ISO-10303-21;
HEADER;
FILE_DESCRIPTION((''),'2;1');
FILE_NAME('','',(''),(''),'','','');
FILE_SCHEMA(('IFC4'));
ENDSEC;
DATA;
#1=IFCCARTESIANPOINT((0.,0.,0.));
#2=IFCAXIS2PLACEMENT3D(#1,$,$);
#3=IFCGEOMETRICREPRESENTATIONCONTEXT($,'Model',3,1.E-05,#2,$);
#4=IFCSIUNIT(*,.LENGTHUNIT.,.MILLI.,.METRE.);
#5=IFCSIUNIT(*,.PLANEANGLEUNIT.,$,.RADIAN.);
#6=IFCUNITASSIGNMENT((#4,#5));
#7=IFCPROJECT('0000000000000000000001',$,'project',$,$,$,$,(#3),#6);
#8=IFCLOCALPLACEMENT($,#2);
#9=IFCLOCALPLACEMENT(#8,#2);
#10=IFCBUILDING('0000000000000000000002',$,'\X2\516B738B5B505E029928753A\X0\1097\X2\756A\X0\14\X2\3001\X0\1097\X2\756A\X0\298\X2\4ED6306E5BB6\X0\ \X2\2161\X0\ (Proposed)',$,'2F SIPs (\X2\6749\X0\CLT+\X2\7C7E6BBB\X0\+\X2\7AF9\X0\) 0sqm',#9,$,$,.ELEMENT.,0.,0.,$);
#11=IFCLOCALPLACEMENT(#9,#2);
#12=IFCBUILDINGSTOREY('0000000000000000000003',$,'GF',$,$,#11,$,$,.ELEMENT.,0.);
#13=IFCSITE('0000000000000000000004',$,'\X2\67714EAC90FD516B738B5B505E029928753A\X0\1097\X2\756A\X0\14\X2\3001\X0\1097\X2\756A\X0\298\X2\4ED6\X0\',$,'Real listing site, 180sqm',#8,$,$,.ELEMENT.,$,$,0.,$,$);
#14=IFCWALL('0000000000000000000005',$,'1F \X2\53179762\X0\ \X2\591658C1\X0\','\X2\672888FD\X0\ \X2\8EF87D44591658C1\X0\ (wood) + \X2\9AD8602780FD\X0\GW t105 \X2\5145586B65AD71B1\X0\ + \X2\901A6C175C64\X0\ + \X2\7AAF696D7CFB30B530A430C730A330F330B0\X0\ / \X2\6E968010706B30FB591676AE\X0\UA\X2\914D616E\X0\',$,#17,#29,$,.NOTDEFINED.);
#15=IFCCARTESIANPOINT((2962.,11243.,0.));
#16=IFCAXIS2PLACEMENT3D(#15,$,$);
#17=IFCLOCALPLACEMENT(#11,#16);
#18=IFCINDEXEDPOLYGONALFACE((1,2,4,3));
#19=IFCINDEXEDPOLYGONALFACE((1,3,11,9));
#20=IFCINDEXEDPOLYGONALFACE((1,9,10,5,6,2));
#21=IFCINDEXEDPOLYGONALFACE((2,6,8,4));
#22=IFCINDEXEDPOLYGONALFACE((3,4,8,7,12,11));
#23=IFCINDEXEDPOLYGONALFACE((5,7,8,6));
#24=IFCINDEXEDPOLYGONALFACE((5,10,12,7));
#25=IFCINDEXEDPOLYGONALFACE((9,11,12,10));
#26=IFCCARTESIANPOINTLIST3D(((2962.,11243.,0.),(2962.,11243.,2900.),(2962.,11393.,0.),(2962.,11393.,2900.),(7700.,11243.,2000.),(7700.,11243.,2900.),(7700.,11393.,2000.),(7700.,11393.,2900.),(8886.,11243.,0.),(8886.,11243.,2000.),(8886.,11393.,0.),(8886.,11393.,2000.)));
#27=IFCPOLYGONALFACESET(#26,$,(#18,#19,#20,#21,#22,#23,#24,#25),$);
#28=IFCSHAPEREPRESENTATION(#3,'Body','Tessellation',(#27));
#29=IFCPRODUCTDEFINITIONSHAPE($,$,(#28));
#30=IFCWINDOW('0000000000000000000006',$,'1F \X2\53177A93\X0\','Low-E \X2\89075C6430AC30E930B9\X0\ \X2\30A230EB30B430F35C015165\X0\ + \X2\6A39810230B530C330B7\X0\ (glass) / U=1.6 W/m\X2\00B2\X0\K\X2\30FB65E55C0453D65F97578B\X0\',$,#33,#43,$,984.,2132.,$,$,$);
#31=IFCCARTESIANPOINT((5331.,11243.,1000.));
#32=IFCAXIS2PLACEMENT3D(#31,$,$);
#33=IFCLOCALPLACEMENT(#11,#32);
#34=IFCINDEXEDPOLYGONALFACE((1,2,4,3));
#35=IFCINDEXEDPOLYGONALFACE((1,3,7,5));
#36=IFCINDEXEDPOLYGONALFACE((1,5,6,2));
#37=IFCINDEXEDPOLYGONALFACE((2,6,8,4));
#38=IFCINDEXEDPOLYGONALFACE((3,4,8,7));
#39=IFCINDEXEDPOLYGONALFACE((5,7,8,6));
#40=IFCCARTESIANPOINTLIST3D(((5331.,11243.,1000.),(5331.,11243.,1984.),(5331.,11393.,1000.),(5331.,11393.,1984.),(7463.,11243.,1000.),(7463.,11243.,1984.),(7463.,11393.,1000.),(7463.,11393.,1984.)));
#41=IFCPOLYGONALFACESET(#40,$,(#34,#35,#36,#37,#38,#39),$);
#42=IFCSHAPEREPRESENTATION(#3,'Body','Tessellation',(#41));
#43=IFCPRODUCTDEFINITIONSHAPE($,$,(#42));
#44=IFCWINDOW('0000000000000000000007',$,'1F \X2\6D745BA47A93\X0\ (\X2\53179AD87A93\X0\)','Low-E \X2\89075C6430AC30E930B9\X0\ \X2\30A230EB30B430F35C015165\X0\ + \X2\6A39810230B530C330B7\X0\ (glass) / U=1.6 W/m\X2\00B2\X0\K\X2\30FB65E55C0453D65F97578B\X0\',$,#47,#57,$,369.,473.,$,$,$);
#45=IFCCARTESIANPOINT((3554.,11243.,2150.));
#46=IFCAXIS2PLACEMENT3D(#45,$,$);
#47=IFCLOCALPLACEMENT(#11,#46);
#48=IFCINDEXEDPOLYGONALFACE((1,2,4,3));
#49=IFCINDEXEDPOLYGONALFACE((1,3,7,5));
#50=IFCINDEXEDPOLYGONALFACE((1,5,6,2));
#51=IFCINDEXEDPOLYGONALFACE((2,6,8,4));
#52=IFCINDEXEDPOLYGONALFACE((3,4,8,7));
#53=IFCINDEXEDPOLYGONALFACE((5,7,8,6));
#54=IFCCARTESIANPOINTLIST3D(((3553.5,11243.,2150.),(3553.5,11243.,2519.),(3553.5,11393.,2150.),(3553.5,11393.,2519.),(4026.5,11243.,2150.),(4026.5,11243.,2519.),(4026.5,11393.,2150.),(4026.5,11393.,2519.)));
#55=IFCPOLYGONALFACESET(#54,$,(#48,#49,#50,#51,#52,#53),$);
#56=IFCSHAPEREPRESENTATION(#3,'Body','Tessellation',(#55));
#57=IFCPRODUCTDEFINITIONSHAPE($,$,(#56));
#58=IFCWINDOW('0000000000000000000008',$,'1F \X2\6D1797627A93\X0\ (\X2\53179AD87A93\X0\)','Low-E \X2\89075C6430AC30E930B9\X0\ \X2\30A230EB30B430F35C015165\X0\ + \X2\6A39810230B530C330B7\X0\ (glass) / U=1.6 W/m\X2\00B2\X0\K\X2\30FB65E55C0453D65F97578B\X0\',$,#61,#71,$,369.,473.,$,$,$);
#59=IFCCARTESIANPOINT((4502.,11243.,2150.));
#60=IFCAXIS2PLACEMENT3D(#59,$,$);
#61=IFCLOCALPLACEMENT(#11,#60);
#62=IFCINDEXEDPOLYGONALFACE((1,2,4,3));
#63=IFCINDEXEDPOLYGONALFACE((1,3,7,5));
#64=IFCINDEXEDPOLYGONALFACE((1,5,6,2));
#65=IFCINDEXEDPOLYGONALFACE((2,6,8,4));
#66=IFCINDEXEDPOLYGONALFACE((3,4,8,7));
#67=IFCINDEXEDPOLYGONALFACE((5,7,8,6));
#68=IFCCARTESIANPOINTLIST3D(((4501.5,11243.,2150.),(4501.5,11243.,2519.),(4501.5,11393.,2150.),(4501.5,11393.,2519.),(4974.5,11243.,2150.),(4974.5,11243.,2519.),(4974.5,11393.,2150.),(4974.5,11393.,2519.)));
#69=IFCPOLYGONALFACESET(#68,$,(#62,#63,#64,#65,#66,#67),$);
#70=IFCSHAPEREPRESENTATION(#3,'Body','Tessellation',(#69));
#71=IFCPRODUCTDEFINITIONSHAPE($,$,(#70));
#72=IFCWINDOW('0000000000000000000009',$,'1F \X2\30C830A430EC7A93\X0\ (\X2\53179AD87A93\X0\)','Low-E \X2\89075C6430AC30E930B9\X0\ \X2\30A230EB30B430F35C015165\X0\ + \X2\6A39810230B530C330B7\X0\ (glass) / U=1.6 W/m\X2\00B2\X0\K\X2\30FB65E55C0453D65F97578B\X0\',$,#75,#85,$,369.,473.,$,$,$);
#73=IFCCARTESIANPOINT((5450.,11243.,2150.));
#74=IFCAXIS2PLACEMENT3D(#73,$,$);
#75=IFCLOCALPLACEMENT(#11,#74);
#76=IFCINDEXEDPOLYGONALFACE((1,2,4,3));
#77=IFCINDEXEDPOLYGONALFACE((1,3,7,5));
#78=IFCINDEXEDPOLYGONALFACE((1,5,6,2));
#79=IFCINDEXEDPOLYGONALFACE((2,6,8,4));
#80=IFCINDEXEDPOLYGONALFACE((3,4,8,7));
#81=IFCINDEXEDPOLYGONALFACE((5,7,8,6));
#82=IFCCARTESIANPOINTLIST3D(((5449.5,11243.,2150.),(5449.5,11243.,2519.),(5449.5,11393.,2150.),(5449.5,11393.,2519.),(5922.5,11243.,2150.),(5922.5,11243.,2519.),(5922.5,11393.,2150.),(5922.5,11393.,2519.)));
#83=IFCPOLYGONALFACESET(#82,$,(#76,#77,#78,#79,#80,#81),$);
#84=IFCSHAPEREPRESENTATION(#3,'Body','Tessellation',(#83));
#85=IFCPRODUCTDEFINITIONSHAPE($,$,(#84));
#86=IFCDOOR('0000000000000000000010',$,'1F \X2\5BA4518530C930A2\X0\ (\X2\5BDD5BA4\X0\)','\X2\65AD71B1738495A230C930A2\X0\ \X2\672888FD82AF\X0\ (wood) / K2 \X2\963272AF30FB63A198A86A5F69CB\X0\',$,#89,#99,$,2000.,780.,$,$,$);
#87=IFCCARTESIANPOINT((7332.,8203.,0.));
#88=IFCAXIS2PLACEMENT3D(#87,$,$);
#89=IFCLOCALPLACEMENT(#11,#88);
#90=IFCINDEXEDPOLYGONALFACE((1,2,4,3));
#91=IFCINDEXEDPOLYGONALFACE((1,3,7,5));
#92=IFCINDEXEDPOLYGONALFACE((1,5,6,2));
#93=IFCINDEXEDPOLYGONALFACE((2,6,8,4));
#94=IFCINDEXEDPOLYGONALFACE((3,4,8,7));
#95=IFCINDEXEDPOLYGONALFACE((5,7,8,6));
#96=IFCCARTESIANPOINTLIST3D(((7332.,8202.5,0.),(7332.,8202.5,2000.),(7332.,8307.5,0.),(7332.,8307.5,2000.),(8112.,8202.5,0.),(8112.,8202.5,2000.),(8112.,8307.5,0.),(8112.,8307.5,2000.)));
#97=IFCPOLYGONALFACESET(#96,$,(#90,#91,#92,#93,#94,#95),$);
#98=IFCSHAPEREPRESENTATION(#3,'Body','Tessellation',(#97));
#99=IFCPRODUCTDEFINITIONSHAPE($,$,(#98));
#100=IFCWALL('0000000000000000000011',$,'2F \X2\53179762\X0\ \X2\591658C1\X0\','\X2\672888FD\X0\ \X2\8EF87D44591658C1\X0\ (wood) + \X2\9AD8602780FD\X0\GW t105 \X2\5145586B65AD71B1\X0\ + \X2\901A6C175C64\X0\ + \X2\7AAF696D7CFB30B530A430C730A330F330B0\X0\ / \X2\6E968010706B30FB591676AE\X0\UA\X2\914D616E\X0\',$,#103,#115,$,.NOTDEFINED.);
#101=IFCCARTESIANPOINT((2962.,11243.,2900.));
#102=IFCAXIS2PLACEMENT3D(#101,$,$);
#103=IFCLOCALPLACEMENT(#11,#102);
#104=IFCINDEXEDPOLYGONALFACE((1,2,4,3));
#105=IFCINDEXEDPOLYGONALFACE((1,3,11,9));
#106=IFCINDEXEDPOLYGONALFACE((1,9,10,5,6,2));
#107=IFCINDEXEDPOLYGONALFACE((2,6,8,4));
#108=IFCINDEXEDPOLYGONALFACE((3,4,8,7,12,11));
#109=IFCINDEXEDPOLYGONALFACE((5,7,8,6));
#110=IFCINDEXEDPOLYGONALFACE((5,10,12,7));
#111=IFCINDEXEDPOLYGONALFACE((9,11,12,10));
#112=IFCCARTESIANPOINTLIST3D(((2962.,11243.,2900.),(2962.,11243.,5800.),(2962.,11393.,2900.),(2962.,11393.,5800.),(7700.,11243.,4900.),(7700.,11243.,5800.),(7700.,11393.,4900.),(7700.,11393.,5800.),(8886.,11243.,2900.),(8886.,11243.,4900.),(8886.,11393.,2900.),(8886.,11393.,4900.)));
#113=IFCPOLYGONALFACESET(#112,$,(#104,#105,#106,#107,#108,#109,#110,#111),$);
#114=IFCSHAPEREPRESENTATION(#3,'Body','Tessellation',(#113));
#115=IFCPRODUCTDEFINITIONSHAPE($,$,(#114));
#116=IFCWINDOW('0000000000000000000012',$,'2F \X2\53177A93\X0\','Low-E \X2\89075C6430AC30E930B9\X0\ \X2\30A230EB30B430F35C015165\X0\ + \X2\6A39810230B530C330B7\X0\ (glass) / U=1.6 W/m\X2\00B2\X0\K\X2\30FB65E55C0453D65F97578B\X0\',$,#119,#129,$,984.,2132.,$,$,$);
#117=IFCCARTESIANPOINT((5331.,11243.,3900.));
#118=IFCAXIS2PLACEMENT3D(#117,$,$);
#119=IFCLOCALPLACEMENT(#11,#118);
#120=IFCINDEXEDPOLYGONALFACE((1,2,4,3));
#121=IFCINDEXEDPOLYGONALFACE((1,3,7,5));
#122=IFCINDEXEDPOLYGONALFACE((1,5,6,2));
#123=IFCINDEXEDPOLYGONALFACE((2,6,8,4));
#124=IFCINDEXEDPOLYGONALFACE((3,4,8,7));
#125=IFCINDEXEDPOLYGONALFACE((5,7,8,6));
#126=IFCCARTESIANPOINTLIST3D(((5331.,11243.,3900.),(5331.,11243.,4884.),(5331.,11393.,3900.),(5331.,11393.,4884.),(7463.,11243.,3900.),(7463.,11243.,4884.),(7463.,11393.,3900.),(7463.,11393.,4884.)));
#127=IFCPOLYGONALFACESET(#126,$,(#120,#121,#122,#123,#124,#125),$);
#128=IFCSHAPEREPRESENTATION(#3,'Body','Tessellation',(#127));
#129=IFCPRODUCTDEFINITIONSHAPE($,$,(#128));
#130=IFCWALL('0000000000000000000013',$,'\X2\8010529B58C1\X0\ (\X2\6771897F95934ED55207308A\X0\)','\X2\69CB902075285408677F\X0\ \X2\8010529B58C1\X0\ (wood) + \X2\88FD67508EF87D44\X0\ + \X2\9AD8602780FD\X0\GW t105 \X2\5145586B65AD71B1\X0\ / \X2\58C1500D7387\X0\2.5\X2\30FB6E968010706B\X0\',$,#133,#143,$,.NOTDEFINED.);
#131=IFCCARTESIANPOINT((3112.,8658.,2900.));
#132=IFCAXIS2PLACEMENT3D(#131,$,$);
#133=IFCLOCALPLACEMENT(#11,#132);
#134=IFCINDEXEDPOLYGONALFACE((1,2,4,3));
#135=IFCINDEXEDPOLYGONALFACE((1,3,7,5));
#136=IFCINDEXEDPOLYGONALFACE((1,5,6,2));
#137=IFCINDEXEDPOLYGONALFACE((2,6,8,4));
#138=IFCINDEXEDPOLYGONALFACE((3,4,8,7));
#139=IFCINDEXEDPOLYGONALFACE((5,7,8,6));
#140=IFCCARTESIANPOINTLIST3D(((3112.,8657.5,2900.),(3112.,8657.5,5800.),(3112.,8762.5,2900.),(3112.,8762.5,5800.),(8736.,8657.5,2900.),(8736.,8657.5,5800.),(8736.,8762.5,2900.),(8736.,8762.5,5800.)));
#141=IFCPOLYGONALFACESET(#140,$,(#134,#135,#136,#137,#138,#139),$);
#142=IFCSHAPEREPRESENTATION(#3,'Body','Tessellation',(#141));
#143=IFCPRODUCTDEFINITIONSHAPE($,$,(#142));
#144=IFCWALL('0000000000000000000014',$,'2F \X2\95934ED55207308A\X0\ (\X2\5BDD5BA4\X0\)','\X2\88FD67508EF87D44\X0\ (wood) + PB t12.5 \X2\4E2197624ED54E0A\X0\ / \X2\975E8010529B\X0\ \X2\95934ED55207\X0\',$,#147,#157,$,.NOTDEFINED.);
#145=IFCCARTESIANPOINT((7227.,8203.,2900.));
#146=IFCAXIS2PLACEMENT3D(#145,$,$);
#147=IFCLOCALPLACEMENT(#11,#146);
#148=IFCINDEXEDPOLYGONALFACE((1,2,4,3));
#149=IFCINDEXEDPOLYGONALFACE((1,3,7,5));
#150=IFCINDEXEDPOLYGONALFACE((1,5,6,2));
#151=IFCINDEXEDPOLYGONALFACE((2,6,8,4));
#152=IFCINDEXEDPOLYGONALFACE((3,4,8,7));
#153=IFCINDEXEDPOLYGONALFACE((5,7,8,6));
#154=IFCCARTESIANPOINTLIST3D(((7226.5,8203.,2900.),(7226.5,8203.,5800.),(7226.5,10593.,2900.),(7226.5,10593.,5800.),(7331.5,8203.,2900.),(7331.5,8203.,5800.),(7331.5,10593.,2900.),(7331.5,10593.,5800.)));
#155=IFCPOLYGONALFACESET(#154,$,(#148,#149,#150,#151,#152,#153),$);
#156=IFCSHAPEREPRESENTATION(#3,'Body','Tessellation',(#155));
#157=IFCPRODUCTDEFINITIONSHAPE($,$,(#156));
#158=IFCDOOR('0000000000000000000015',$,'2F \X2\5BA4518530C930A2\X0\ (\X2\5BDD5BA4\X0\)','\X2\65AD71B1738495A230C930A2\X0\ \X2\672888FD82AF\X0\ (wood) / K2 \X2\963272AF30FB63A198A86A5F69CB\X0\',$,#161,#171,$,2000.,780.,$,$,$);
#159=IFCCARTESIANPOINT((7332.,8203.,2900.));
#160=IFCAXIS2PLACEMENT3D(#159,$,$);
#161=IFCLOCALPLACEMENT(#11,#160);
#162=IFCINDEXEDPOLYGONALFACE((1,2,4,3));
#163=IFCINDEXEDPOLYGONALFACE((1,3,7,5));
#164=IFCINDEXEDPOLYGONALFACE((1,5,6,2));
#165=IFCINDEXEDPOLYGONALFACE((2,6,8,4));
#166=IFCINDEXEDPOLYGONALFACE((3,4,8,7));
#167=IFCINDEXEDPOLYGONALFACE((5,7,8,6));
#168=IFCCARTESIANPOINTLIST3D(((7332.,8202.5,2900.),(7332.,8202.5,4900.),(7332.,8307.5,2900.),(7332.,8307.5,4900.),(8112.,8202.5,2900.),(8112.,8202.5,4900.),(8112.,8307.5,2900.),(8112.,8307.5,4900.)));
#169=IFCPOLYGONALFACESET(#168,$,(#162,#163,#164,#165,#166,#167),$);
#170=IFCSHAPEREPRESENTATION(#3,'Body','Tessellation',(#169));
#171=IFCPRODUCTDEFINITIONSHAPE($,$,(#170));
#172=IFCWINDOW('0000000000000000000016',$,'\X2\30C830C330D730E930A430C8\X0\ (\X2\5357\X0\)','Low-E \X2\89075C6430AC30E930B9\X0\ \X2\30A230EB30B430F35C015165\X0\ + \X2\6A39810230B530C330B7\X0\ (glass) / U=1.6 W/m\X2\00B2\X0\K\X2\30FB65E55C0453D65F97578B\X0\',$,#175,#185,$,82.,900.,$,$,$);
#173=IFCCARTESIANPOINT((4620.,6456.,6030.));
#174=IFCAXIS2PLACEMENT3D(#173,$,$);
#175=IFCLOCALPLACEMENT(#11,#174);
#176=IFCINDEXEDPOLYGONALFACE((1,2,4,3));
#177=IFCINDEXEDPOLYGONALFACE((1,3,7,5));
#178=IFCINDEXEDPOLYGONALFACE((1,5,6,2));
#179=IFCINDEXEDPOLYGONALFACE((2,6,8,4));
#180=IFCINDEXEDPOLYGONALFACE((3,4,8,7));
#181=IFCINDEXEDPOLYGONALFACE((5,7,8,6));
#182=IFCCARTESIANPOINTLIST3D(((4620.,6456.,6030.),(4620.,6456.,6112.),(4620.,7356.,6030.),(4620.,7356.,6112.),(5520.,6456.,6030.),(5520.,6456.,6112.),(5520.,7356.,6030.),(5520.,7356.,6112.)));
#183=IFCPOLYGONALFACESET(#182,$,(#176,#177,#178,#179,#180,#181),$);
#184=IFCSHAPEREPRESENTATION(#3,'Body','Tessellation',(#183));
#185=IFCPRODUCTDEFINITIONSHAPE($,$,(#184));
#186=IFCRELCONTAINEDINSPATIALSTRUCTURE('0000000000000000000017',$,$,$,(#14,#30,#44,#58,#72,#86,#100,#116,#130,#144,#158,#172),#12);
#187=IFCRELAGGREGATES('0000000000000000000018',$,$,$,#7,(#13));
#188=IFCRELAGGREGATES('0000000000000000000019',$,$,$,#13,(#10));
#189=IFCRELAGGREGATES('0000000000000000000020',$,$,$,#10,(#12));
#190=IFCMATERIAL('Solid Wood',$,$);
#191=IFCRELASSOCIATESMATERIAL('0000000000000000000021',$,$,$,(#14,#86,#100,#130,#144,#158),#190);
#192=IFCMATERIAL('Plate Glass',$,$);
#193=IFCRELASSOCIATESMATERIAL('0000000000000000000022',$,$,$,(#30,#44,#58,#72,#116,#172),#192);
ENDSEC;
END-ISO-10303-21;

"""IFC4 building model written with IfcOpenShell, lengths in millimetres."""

from ifc_helpers import new_model, si_unit, frame, frame_2d, origin, place, context, project, spatial, rectangle, extrude, material, element, fill, save


model = new_model("IFC4")

# Units and contexts
model_context = context("Model", 3, precision=1e-05, world=origin())
ifc_project = project(units=[si_unit("LENGTHUNIT", "METRE", prefix="MILLI"), si_unit("PLANEANGLEUNIT", "RADIAN")], contexts=[model_context])

# Site, building, storey
site_placement = place(None, origin())
site = spatial("IfcSite", under=ifc_project, at=site_placement, Name="東京都八王子市館町1097番14、1097番298他", ObjectType="Real listing site, 180sqm", CompositionType="ELEMENT", RefElevation=0.0)
building_placement = place(site_placement, origin())
building = spatial("IfcBuilding", under=site, at=building_placement, Name="八王子市館町1097番14、1097番298他の家 Ⅱ (Proposed)", ObjectType="2F SIPs (杉CLT+籾殻+竹) 0sqm", CompositionType="ELEMENT", ElevationOfRefHeight=0.0, ElevationOfTerrain=0.0)
storey_placement = place(building_placement, origin())
storey = spatial("IfcBuildingStorey", under=building, at=storey_placement, Name="GF", CompositionType="ELEMENT", Elevation=0.0)

# Wall, openings, windows
ifc_material_1 = material(Name="Solid Wood")
wall_1_placement = place(storey_placement, frame((2962.0, 11243.0, 0.0)))
wall_1 = element("IfcWall", 1, at=wall_1_placement, inside=storey, material=ifc_material_1, Name="1F 北面 外壁", Description="木製 軸組外壁 (wood) + 高性能GW t105 充填断熱 + 通気層 + 窯業系サイディング / 準耐火・外皮UA配慮", PredefinedType="NOTDEFINED", context=model_context, shape_type="SweptSolid", body=[
    extrude(rectangle(XDim=5924.0, YDim=150.0, at=frame_2d((2962.0, 75.0))), frame((2962.0, 11243.0, 0.0)), (0.0, 0.0, 1.0), 2900.0),
])
opening_1_placement = place(storey_placement, frame((5331.0, 11243.0, 1000.0)))
opening_1 = element("IfcOpeningElement", 2, at=opening_1_placement, cuts=wall_1, PredefinedType="NOTDEFINED", context=model_context, shape_type="SweptSolid", body=[
    extrude(rectangle(XDim=2132.0, YDim=150.0, at=frame_2d((1066.0, 75.0))), frame((5331.0, 11243.0, 1000.0)), (0.0, 0.0, 1.0), 984.0),
])
opening_2_placement = place(storey_placement, frame((3554.0, 11243.0, 2150.0)))
opening_2 = element("IfcOpeningElement", 3, at=opening_2_placement, cuts=wall_1, PredefinedType="NOTDEFINED", context=model_context, shape_type="SweptSolid", body=[
    extrude(rectangle(XDim=473.0, YDim=150.0, at=frame_2d((236.0, 75.0))), frame((3554.0, 11243.0, 2150.0)), (0.0, 0.0, 1.0), 369.0),
])
opening_3_placement = place(storey_placement, frame((4502.0, 11243.0, 2150.0)))
opening_3 = element("IfcOpeningElement", 4, at=opening_3_placement, cuts=wall_1, PredefinedType="NOTDEFINED", context=model_context, shape_type="SweptSolid", body=[
    extrude(rectangle(XDim=473.0, YDim=150.0, at=frame_2d((236.0, 75.0))), frame((4502.0, 11243.0, 2150.0)), (0.0, 0.0, 1.0), 369.0),
])
opening_4_placement = place(storey_placement, frame((5450.0, 11243.0, 2150.0)))
opening_4 = element("IfcOpeningElement", 5, at=opening_4_placement, cuts=wall_1, PredefinedType="NOTDEFINED", context=model_context, shape_type="SweptSolid", body=[
    extrude(rectangle(XDim=473.0, YDim=150.0, at=frame_2d((236.0, 75.0))), frame((5450.0, 11243.0, 2150.0)), (0.0, 0.0, 1.0), 369.0),
])
ifc_material_2 = material(Name="Plate Glass")
window_1_placement = place(storey_placement, frame((5331.0, 11243.0, 1000.0)))
window_1 = element("IfcWindow", 6, at=window_1_placement, inside=storey, material=ifc_material_2, Name="1F 北窓", Description="Low-E 複層ガラス アルゴン封入 + 樹脂サッシ (glass) / U=1.6 W/m²K・日射取得型", OverallHeight=984.0, OverallWidth=2132.0, context=model_context, shape_type="SweptSolid", body=[
    extrude(rectangle(XDim=2132.0, YDim=150.0, at=frame_2d((1066.0, 75.0))), frame((5331.0, 11243.0, 1000.0)), (0.0, 0.0, 1.0), 984.0),
])
fill(opening_1, window_1)
window_2_placement = place(storey_placement, frame((3554.0, 11243.0, 2150.0)))
window_2 = element("IfcWindow", 7, at=window_2_placement, inside=storey, material=ifc_material_2, Name="1F 浴室窓 (北高窓)", Description="Low-E 複層ガラス アルゴン封入 + 樹脂サッシ (glass) / U=1.6 W/m²K・日射取得型", OverallHeight=369.0, OverallWidth=473.0, context=model_context, shape_type="SweptSolid", body=[
    extrude(rectangle(XDim=473.0, YDim=150.0, at=frame_2d((236.0, 75.0))), frame((3554.0, 11243.0, 2150.0)), (0.0, 0.0, 1.0), 369.0),
])
fill(opening_2, window_2)
window_3_placement = place(storey_placement, frame((4502.0, 11243.0, 2150.0)))
window_3 = element("IfcWindow", 8, at=window_3_placement, inside=storey, material=ifc_material_2, Name="1F 洗面窓 (北高窓)", Description="Low-E 複層ガラス アルゴン封入 + 樹脂サッシ (glass) / U=1.6 W/m²K・日射取得型", OverallHeight=369.0, OverallWidth=473.0, context=model_context, shape_type="SweptSolid", body=[
    extrude(rectangle(XDim=473.0, YDim=150.0, at=frame_2d((236.0, 75.0))), frame((4502.0, 11243.0, 2150.0)), (0.0, 0.0, 1.0), 369.0),
])
fill(opening_3, window_3)
window_4_placement = place(storey_placement, frame((5450.0, 11243.0, 2150.0)))
window_4 = element("IfcWindow", 9, at=window_4_placement, inside=storey, material=ifc_material_2, Name="1F トイレ窓 (北高窓)", Description="Low-E 複層ガラス アルゴン封入 + 樹脂サッシ (glass) / U=1.6 W/m²K・日射取得型", OverallHeight=369.0, OverallWidth=473.0, context=model_context, shape_type="SweptSolid", body=[
    extrude(rectangle(XDim=473.0, YDim=150.0, at=frame_2d((236.0, 75.0))), frame((5450.0, 11243.0, 2150.0)), (0.0, 0.0, 1.0), 369.0),
])
fill(opening_4, window_4)

# Door
door_1_placement = place(storey_placement, frame((7332.0, 8203.0, 0.0)))
element("IfcDoor", 10, at=door_1_placement, inside=storey, material=ifc_material_1, Name="1F 室内ドア (寝室)", Description="断熱玄関ドア 木製芯 (wood) / K2 防犯・採風機構", OverallHeight=2000.0, OverallWidth=780.0, context=model_context, shape_type="SweptSolid", body=[
    extrude(rectangle(XDim=780.0, YDim=105.0, at=frame_2d((390.0, 52.0))), frame((7332.0, 8203.0, 0.0)), (0.0, 0.0, 1.0), 2000.0),
])

# Wall, opening, window
wall_2_placement = place(storey_placement, frame((2962.0, 11243.0, 2900.0)))
wall_2 = element("IfcWall", 11, at=wall_2_placement, inside=storey, material=ifc_material_1, Name="2F 北面 外壁", Description="木製 軸組外壁 (wood) + 高性能GW t105 充填断熱 + 通気層 + 窯業系サイディング / 準耐火・外皮UA配慮", PredefinedType="NOTDEFINED", context=model_context, shape_type="SweptSolid", body=[
    extrude(rectangle(XDim=5924.0, YDim=150.0, at=frame_2d((2962.0, 75.0))), frame((2962.0, 11243.0, 2900.0)), (0.0, 0.0, 1.0), 2900.0),
])
opening_5_placement = place(storey_placement, frame((5331.0, 11243.0, 3900.0)))
opening_5 = element("IfcOpeningElement", 12, at=opening_5_placement, cuts=wall_2, PredefinedType="NOTDEFINED", context=model_context, shape_type="SweptSolid", body=[
    extrude(rectangle(XDim=2132.0, YDim=150.0, at=frame_2d((1066.0, 75.0))), frame((5331.0, 11243.0, 3900.0)), (0.0, 0.0, 1.0), 984.0),
])
window_5_placement = place(storey_placement, frame((5331.0, 11243.0, 3900.0)))
window_5 = element("IfcWindow", 13, at=window_5_placement, inside=storey, material=ifc_material_2, Name="2F 北窓", Description="Low-E 複層ガラス アルゴン封入 + 樹脂サッシ (glass) / U=1.6 W/m²K・日射取得型", OverallHeight=984.0, OverallWidth=2132.0, context=model_context, shape_type="SweptSolid", body=[
    extrude(rectangle(XDim=2132.0, YDim=150.0, at=frame_2d((1066.0, 75.0))), frame((5331.0, 11243.0, 3900.0)), (0.0, 0.0, 1.0), 984.0),
])
fill(opening_5, window_5)

# Walls
wall_3_placement = place(storey_placement, frame((3112.0, 8658.0, 2900.0)))
element("IfcWall", 14, at=wall_3_placement, inside=storey, material=ifc_material_1, Name="耐力壁 (東西間仕切り)", Description="構造用合板 耐力壁 (wood) + 製材軸組 + 高性能GW t105 充填断熱 / 壁倍率2.5・準耐火", PredefinedType="NOTDEFINED", context=model_context, shape_type="SweptSolid", body=[
    extrude(rectangle(XDim=5624.0, YDim=105.0, at=frame_2d((2812.0, 52.0))), frame((3112.0, 8658.0, 2900.0)), (0.0, 0.0, 1.0), 2900.0),
])
wall_4_placement = place(storey_placement, frame((7227.0, 8203.0, 2900.0)))
element("IfcWall", 15, at=wall_4_placement, inside=storey, material=ifc_material_1, Name="2F 間仕切り (寝室)", Description="製材軸組 (wood) + PB t12.5 両面仕上 / 非耐力 間仕切", PredefinedType="NOTDEFINED", context=model_context, shape_type="SweptSolid", body=[
    extrude(rectangle(XDim=105.0, YDim=2390.0, at=frame_2d((52.0, 1195.0))), frame((7227.0, 8203.0, 2900.0)), (0.0, 0.0, 1.0), 2900.0),
])

# Door
door_2_placement = place(storey_placement, frame((7332.0, 8203.0, 2900.0)))
element("IfcDoor", 16, at=door_2_placement, inside=storey, material=ifc_material_1, Name="2F 室内ドア (寝室)", Description="断熱玄関ドア 木製芯 (wood) / K2 防犯・採風機構", OverallHeight=2000.0, OverallWidth=780.0, context=model_context, shape_type="SweptSolid", body=[
    extrude(rectangle(XDim=780.0, YDim=105.0, at=frame_2d((390.0, 52.0))), frame((7332.0, 8203.0, 2900.0)), (0.0, 0.0, 1.0), 2000.0),
])

# Window
window_6_placement = place(storey_placement, frame((4620.0, 6456.0, 6030.0)))
element("IfcWindow", 17, at=window_6_placement, inside=storey, material=ifc_material_2, Name="トップライト (南)", Description="Low-E 複層ガラス アルゴン封入 + 樹脂サッシ (glass) / U=1.6 W/m²K・日射取得型", OverallHeight=82.0, OverallWidth=900.0, context=model_context, shape_type="SweptSolid", body=[
    extrude(rectangle(XDim=900.0, YDim=900.0, at=frame_2d((450.0, 450.0))), frame((4620.0, 6456.0, 6030.0)), (0.0, 0.0, 1.0), 82.0),
])

save(model, "model.ifc")
